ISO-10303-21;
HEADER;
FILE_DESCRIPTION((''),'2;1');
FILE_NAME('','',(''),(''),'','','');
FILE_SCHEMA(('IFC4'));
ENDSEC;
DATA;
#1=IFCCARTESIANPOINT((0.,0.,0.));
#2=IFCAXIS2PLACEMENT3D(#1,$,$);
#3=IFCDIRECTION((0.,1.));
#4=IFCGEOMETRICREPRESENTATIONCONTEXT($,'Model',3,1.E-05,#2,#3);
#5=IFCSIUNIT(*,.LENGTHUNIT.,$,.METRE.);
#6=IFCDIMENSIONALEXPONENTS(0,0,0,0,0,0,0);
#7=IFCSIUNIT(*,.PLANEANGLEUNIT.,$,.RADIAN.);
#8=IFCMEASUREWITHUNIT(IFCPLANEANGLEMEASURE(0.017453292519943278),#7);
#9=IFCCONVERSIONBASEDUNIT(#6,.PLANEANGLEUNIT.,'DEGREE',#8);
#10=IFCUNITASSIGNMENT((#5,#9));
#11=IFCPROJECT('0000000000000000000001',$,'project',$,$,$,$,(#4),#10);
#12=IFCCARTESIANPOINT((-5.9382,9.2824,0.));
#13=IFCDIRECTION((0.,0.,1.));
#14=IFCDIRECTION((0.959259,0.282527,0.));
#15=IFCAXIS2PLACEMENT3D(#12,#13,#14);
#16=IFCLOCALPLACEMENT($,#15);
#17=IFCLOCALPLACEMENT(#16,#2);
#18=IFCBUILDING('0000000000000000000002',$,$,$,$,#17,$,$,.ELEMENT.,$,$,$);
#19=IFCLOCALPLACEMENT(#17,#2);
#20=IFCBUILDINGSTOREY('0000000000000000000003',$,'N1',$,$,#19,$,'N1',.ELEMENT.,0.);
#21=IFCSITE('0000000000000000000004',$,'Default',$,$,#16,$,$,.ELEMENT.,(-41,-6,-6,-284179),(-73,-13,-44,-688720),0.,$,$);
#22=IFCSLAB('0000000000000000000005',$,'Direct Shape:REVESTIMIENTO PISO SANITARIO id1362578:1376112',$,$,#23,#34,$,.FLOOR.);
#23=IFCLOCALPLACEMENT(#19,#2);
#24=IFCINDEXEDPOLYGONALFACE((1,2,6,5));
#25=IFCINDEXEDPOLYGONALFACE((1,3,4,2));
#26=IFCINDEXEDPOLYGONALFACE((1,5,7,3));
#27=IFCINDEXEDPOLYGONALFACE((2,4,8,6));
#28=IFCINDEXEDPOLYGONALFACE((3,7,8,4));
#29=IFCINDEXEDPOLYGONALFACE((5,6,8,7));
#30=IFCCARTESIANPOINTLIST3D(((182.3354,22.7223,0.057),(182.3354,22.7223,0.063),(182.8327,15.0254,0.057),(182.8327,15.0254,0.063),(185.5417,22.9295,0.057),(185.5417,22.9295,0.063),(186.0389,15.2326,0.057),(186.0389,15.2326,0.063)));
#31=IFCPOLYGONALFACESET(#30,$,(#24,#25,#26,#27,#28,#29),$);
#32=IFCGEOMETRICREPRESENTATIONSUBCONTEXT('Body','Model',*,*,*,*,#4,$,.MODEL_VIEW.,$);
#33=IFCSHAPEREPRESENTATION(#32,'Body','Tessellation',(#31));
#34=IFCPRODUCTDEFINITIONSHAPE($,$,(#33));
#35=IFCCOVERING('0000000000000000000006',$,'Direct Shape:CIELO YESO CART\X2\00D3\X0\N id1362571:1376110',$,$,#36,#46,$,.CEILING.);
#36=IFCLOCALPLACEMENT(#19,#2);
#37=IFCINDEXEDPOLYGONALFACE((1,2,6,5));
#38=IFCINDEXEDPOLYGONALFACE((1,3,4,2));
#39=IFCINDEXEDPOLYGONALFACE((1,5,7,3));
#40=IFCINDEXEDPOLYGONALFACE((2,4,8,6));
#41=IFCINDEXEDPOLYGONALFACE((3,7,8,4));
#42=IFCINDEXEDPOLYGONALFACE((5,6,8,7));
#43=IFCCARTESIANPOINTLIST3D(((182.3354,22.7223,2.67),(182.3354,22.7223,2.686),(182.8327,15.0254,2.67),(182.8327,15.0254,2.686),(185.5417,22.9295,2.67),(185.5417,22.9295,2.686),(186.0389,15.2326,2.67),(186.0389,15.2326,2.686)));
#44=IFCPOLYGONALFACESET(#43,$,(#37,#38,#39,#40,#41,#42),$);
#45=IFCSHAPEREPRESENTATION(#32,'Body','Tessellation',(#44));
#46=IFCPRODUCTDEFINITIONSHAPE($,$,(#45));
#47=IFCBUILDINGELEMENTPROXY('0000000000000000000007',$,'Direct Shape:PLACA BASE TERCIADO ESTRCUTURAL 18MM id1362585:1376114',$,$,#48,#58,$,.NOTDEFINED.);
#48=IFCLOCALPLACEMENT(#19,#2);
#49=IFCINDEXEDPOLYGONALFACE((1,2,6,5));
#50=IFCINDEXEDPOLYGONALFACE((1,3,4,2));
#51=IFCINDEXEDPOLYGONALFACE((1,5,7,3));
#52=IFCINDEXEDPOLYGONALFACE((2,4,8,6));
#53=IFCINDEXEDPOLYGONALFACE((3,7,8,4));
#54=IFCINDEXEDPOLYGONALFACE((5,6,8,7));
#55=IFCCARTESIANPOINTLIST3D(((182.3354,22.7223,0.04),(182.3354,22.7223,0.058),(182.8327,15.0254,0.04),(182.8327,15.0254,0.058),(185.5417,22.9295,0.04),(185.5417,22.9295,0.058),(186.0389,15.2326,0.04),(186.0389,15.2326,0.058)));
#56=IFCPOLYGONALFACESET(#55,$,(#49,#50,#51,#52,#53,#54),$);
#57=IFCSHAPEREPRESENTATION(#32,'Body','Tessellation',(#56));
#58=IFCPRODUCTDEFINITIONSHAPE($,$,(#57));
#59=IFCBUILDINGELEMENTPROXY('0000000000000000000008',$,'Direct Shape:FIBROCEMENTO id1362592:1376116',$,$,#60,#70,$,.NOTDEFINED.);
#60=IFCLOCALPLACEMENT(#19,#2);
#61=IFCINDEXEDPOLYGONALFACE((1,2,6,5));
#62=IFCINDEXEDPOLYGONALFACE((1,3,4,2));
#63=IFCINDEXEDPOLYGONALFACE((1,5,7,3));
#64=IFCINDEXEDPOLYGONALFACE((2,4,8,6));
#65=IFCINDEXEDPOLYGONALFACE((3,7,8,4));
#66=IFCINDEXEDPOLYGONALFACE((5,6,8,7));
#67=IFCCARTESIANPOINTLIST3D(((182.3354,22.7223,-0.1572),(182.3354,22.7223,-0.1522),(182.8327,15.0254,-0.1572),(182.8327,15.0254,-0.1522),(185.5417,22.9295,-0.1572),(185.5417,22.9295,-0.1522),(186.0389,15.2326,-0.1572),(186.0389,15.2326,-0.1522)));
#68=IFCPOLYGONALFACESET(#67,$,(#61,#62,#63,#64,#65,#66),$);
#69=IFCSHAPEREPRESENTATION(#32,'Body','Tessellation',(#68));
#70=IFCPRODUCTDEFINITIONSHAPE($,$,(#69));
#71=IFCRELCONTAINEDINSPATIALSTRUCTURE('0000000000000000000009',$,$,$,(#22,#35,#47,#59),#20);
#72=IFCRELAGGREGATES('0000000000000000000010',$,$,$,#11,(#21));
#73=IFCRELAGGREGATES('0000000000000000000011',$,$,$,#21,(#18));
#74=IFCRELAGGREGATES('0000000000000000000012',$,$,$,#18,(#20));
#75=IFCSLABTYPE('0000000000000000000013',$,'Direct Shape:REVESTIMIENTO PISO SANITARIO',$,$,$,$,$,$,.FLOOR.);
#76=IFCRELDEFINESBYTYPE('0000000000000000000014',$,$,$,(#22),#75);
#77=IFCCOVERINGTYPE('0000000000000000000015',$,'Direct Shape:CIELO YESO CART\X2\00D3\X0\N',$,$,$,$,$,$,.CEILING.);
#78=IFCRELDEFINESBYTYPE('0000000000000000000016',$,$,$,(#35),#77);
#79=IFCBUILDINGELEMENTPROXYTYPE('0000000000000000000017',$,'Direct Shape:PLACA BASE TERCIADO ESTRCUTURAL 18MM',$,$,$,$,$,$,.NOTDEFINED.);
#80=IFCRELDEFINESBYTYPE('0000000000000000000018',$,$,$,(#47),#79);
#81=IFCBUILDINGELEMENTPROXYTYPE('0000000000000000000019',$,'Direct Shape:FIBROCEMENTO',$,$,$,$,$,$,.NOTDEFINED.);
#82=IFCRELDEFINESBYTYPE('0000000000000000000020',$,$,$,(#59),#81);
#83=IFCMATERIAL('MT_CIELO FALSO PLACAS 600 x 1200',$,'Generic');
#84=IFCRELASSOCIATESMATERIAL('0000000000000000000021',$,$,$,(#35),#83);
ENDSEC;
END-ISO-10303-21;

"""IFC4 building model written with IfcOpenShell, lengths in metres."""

from ifc_helpers import new_model, entity, si_unit, converted_unit, direction, frame, frame_2d, origin, origin_2d_with_axis, place, context, subcontext, project, spatial, rectangle, extrude, material, type_object, element, save


model = new_model("IFC4")

# Units and contexts
model_context = context("Model", 3, precision=1e-05, world=origin(), true_north=direction((0.0, 1.0)))
body_context = subcontext(model_context, "Body", "Model", "MODEL_VIEW")
ifc_project = project(units=[si_unit("LENGTHUNIT", "METRE"), converted_unit("PLANEANGLEUNIT", "DEGREE", entity("IfcPlaneAngleMeasure", 0.017453292519943278), si_unit("PLANEANGLEUNIT", "RADIAN"), dimensions=[0, 0, 0, 0, 0, 0, 0])], contexts=[model_context])

# Site, building, storey
site_placement = place(None, frame((-5.9382, 9.2824, 0.0), z_axis=(0.0, 0.0, 1.0), x_axis=(0.959259, 0.282527, 0.0)))
site = spatial("IfcSite", under=ifc_project, at=site_placement, Name="Default", CompositionType="ELEMENT", RefLatitude=(-41, -6, -6, -284179), RefLongitude=(-73, -13, -44, -688720), RefElevation=0.0)
building_placement = place(site_placement, origin())
building = spatial("IfcBuilding", under=site, at=building_placement, CompositionType="ELEMENT")
storey_placement = place(building_placement, origin())
storey = spatial("IfcBuildingStorey", under=building, at=storey_placement, Name="N1", LongName="N1", CompositionType="ELEMENT", Elevation=0.0)

# Slab
slab_type = type_object("IfcSlabType", Name="Direct Shape:REVESTIMIENTO PISO SANITARIO", PredefinedType="FLOOR")
slab_placement = place(storey_placement, origin())
element("IfcSlab", 1, at=slab_placement, inside=storey, type_object=slab_type, Name="Direct Shape:REVESTIMIENTO PISO SANITARIO id1362578:1376112", PredefinedType="FLOOR", context=body_context, shape_type="SweptSolid", body=[
    extrude(rectangle(XDim=7.7129, YDim=3.2129, at=origin_2d_with_axis()), frame((184.1872, 18.9775, 0.057), z_axis=(0.0, 0.0, 1.0), x_axis=(-0.064471, 0.99792, 0.0)), (0.0, 0.0, 1.0), 0.006),
])

# Covering
ifc_material = material(Name="MT_CIELO FALSO PLACAS 600 x 1200", Category="Generic")
covering_type = type_object("IfcCoveringType", Name="Direct Shape:CIELO YESO CARTÓN", PredefinedType="CEILING")
covering_placement = place(storey_placement, origin())
element("IfcCovering", 2, at=covering_placement, inside=storey, type_object=covering_type, material=ifc_material, Name="Direct Shape:CIELO YESO CARTÓN id1362571:1376110", PredefinedType="CEILING", context=body_context, shape_type="SweptSolid", body=[
    extrude(rectangle(XDim=7.7129, YDim=3.2129, at=frame_2d((0.0, 0.0), x_axis=(1.0, 0.0))), frame((184.1872, 18.9775, 2.67), z_axis=(0.0, 0.0, 1.0), x_axis=(-0.064471, 0.99792, 0.0)), (0.0, 0.0, 1.0), 0.016),
])

# Building element proxies
building_element_proxy_type_1 = type_object("IfcBuildingElementProxyType", Name="Direct Shape:PLACA BASE TERCIADO ESTRCUTURAL 18MM", PredefinedType="NOTDEFINED")
proxy_1_placement = place(storey_placement, origin())
element("IfcBuildingElementProxy", 3, at=proxy_1_placement, inside=storey, type_object=building_element_proxy_type_1, Name="Direct Shape:PLACA BASE TERCIADO ESTRCUTURAL 18MM id1362585:1376114", PredefinedType="NOTDEFINED", context=body_context, shape_type="SweptSolid", body=[
    extrude(rectangle(XDim=7.7129, YDim=3.2129, at=origin_2d_with_axis()), frame((184.1872, 18.9775, 0.04), z_axis=(0.0, 0.0, 1.0), x_axis=(-0.064471, 0.99792, 0.0)), (0.0, 0.0, 1.0), 0.018),
])
building_element_proxy_type_2 = type_object("IfcBuildingElementProxyType", Name="Direct Shape:FIBROCEMENTO", PredefinedType="NOTDEFINED")
proxy_2_placement = place(storey_placement, origin())
element("IfcBuildingElementProxy", 4, at=proxy_2_placement, inside=storey, type_object=building_element_proxy_type_2, Name="Direct Shape:FIBROCEMENTO id1362592:1376116", PredefinedType="NOTDEFINED", context=body_context, shape_type="SweptSolid", body=[
    extrude(rectangle(XDim=7.7129, YDim=3.2129, at=origin_2d_with_axis()), frame((184.1872, 18.9775, -0.1572), z_axis=(0.0, 0.0, 1.0), x_axis=(-0.064471, 0.99792, 0.0)), (0.0, 0.0, 1.0), 0.005),
])

save(model, "model.ifc")
